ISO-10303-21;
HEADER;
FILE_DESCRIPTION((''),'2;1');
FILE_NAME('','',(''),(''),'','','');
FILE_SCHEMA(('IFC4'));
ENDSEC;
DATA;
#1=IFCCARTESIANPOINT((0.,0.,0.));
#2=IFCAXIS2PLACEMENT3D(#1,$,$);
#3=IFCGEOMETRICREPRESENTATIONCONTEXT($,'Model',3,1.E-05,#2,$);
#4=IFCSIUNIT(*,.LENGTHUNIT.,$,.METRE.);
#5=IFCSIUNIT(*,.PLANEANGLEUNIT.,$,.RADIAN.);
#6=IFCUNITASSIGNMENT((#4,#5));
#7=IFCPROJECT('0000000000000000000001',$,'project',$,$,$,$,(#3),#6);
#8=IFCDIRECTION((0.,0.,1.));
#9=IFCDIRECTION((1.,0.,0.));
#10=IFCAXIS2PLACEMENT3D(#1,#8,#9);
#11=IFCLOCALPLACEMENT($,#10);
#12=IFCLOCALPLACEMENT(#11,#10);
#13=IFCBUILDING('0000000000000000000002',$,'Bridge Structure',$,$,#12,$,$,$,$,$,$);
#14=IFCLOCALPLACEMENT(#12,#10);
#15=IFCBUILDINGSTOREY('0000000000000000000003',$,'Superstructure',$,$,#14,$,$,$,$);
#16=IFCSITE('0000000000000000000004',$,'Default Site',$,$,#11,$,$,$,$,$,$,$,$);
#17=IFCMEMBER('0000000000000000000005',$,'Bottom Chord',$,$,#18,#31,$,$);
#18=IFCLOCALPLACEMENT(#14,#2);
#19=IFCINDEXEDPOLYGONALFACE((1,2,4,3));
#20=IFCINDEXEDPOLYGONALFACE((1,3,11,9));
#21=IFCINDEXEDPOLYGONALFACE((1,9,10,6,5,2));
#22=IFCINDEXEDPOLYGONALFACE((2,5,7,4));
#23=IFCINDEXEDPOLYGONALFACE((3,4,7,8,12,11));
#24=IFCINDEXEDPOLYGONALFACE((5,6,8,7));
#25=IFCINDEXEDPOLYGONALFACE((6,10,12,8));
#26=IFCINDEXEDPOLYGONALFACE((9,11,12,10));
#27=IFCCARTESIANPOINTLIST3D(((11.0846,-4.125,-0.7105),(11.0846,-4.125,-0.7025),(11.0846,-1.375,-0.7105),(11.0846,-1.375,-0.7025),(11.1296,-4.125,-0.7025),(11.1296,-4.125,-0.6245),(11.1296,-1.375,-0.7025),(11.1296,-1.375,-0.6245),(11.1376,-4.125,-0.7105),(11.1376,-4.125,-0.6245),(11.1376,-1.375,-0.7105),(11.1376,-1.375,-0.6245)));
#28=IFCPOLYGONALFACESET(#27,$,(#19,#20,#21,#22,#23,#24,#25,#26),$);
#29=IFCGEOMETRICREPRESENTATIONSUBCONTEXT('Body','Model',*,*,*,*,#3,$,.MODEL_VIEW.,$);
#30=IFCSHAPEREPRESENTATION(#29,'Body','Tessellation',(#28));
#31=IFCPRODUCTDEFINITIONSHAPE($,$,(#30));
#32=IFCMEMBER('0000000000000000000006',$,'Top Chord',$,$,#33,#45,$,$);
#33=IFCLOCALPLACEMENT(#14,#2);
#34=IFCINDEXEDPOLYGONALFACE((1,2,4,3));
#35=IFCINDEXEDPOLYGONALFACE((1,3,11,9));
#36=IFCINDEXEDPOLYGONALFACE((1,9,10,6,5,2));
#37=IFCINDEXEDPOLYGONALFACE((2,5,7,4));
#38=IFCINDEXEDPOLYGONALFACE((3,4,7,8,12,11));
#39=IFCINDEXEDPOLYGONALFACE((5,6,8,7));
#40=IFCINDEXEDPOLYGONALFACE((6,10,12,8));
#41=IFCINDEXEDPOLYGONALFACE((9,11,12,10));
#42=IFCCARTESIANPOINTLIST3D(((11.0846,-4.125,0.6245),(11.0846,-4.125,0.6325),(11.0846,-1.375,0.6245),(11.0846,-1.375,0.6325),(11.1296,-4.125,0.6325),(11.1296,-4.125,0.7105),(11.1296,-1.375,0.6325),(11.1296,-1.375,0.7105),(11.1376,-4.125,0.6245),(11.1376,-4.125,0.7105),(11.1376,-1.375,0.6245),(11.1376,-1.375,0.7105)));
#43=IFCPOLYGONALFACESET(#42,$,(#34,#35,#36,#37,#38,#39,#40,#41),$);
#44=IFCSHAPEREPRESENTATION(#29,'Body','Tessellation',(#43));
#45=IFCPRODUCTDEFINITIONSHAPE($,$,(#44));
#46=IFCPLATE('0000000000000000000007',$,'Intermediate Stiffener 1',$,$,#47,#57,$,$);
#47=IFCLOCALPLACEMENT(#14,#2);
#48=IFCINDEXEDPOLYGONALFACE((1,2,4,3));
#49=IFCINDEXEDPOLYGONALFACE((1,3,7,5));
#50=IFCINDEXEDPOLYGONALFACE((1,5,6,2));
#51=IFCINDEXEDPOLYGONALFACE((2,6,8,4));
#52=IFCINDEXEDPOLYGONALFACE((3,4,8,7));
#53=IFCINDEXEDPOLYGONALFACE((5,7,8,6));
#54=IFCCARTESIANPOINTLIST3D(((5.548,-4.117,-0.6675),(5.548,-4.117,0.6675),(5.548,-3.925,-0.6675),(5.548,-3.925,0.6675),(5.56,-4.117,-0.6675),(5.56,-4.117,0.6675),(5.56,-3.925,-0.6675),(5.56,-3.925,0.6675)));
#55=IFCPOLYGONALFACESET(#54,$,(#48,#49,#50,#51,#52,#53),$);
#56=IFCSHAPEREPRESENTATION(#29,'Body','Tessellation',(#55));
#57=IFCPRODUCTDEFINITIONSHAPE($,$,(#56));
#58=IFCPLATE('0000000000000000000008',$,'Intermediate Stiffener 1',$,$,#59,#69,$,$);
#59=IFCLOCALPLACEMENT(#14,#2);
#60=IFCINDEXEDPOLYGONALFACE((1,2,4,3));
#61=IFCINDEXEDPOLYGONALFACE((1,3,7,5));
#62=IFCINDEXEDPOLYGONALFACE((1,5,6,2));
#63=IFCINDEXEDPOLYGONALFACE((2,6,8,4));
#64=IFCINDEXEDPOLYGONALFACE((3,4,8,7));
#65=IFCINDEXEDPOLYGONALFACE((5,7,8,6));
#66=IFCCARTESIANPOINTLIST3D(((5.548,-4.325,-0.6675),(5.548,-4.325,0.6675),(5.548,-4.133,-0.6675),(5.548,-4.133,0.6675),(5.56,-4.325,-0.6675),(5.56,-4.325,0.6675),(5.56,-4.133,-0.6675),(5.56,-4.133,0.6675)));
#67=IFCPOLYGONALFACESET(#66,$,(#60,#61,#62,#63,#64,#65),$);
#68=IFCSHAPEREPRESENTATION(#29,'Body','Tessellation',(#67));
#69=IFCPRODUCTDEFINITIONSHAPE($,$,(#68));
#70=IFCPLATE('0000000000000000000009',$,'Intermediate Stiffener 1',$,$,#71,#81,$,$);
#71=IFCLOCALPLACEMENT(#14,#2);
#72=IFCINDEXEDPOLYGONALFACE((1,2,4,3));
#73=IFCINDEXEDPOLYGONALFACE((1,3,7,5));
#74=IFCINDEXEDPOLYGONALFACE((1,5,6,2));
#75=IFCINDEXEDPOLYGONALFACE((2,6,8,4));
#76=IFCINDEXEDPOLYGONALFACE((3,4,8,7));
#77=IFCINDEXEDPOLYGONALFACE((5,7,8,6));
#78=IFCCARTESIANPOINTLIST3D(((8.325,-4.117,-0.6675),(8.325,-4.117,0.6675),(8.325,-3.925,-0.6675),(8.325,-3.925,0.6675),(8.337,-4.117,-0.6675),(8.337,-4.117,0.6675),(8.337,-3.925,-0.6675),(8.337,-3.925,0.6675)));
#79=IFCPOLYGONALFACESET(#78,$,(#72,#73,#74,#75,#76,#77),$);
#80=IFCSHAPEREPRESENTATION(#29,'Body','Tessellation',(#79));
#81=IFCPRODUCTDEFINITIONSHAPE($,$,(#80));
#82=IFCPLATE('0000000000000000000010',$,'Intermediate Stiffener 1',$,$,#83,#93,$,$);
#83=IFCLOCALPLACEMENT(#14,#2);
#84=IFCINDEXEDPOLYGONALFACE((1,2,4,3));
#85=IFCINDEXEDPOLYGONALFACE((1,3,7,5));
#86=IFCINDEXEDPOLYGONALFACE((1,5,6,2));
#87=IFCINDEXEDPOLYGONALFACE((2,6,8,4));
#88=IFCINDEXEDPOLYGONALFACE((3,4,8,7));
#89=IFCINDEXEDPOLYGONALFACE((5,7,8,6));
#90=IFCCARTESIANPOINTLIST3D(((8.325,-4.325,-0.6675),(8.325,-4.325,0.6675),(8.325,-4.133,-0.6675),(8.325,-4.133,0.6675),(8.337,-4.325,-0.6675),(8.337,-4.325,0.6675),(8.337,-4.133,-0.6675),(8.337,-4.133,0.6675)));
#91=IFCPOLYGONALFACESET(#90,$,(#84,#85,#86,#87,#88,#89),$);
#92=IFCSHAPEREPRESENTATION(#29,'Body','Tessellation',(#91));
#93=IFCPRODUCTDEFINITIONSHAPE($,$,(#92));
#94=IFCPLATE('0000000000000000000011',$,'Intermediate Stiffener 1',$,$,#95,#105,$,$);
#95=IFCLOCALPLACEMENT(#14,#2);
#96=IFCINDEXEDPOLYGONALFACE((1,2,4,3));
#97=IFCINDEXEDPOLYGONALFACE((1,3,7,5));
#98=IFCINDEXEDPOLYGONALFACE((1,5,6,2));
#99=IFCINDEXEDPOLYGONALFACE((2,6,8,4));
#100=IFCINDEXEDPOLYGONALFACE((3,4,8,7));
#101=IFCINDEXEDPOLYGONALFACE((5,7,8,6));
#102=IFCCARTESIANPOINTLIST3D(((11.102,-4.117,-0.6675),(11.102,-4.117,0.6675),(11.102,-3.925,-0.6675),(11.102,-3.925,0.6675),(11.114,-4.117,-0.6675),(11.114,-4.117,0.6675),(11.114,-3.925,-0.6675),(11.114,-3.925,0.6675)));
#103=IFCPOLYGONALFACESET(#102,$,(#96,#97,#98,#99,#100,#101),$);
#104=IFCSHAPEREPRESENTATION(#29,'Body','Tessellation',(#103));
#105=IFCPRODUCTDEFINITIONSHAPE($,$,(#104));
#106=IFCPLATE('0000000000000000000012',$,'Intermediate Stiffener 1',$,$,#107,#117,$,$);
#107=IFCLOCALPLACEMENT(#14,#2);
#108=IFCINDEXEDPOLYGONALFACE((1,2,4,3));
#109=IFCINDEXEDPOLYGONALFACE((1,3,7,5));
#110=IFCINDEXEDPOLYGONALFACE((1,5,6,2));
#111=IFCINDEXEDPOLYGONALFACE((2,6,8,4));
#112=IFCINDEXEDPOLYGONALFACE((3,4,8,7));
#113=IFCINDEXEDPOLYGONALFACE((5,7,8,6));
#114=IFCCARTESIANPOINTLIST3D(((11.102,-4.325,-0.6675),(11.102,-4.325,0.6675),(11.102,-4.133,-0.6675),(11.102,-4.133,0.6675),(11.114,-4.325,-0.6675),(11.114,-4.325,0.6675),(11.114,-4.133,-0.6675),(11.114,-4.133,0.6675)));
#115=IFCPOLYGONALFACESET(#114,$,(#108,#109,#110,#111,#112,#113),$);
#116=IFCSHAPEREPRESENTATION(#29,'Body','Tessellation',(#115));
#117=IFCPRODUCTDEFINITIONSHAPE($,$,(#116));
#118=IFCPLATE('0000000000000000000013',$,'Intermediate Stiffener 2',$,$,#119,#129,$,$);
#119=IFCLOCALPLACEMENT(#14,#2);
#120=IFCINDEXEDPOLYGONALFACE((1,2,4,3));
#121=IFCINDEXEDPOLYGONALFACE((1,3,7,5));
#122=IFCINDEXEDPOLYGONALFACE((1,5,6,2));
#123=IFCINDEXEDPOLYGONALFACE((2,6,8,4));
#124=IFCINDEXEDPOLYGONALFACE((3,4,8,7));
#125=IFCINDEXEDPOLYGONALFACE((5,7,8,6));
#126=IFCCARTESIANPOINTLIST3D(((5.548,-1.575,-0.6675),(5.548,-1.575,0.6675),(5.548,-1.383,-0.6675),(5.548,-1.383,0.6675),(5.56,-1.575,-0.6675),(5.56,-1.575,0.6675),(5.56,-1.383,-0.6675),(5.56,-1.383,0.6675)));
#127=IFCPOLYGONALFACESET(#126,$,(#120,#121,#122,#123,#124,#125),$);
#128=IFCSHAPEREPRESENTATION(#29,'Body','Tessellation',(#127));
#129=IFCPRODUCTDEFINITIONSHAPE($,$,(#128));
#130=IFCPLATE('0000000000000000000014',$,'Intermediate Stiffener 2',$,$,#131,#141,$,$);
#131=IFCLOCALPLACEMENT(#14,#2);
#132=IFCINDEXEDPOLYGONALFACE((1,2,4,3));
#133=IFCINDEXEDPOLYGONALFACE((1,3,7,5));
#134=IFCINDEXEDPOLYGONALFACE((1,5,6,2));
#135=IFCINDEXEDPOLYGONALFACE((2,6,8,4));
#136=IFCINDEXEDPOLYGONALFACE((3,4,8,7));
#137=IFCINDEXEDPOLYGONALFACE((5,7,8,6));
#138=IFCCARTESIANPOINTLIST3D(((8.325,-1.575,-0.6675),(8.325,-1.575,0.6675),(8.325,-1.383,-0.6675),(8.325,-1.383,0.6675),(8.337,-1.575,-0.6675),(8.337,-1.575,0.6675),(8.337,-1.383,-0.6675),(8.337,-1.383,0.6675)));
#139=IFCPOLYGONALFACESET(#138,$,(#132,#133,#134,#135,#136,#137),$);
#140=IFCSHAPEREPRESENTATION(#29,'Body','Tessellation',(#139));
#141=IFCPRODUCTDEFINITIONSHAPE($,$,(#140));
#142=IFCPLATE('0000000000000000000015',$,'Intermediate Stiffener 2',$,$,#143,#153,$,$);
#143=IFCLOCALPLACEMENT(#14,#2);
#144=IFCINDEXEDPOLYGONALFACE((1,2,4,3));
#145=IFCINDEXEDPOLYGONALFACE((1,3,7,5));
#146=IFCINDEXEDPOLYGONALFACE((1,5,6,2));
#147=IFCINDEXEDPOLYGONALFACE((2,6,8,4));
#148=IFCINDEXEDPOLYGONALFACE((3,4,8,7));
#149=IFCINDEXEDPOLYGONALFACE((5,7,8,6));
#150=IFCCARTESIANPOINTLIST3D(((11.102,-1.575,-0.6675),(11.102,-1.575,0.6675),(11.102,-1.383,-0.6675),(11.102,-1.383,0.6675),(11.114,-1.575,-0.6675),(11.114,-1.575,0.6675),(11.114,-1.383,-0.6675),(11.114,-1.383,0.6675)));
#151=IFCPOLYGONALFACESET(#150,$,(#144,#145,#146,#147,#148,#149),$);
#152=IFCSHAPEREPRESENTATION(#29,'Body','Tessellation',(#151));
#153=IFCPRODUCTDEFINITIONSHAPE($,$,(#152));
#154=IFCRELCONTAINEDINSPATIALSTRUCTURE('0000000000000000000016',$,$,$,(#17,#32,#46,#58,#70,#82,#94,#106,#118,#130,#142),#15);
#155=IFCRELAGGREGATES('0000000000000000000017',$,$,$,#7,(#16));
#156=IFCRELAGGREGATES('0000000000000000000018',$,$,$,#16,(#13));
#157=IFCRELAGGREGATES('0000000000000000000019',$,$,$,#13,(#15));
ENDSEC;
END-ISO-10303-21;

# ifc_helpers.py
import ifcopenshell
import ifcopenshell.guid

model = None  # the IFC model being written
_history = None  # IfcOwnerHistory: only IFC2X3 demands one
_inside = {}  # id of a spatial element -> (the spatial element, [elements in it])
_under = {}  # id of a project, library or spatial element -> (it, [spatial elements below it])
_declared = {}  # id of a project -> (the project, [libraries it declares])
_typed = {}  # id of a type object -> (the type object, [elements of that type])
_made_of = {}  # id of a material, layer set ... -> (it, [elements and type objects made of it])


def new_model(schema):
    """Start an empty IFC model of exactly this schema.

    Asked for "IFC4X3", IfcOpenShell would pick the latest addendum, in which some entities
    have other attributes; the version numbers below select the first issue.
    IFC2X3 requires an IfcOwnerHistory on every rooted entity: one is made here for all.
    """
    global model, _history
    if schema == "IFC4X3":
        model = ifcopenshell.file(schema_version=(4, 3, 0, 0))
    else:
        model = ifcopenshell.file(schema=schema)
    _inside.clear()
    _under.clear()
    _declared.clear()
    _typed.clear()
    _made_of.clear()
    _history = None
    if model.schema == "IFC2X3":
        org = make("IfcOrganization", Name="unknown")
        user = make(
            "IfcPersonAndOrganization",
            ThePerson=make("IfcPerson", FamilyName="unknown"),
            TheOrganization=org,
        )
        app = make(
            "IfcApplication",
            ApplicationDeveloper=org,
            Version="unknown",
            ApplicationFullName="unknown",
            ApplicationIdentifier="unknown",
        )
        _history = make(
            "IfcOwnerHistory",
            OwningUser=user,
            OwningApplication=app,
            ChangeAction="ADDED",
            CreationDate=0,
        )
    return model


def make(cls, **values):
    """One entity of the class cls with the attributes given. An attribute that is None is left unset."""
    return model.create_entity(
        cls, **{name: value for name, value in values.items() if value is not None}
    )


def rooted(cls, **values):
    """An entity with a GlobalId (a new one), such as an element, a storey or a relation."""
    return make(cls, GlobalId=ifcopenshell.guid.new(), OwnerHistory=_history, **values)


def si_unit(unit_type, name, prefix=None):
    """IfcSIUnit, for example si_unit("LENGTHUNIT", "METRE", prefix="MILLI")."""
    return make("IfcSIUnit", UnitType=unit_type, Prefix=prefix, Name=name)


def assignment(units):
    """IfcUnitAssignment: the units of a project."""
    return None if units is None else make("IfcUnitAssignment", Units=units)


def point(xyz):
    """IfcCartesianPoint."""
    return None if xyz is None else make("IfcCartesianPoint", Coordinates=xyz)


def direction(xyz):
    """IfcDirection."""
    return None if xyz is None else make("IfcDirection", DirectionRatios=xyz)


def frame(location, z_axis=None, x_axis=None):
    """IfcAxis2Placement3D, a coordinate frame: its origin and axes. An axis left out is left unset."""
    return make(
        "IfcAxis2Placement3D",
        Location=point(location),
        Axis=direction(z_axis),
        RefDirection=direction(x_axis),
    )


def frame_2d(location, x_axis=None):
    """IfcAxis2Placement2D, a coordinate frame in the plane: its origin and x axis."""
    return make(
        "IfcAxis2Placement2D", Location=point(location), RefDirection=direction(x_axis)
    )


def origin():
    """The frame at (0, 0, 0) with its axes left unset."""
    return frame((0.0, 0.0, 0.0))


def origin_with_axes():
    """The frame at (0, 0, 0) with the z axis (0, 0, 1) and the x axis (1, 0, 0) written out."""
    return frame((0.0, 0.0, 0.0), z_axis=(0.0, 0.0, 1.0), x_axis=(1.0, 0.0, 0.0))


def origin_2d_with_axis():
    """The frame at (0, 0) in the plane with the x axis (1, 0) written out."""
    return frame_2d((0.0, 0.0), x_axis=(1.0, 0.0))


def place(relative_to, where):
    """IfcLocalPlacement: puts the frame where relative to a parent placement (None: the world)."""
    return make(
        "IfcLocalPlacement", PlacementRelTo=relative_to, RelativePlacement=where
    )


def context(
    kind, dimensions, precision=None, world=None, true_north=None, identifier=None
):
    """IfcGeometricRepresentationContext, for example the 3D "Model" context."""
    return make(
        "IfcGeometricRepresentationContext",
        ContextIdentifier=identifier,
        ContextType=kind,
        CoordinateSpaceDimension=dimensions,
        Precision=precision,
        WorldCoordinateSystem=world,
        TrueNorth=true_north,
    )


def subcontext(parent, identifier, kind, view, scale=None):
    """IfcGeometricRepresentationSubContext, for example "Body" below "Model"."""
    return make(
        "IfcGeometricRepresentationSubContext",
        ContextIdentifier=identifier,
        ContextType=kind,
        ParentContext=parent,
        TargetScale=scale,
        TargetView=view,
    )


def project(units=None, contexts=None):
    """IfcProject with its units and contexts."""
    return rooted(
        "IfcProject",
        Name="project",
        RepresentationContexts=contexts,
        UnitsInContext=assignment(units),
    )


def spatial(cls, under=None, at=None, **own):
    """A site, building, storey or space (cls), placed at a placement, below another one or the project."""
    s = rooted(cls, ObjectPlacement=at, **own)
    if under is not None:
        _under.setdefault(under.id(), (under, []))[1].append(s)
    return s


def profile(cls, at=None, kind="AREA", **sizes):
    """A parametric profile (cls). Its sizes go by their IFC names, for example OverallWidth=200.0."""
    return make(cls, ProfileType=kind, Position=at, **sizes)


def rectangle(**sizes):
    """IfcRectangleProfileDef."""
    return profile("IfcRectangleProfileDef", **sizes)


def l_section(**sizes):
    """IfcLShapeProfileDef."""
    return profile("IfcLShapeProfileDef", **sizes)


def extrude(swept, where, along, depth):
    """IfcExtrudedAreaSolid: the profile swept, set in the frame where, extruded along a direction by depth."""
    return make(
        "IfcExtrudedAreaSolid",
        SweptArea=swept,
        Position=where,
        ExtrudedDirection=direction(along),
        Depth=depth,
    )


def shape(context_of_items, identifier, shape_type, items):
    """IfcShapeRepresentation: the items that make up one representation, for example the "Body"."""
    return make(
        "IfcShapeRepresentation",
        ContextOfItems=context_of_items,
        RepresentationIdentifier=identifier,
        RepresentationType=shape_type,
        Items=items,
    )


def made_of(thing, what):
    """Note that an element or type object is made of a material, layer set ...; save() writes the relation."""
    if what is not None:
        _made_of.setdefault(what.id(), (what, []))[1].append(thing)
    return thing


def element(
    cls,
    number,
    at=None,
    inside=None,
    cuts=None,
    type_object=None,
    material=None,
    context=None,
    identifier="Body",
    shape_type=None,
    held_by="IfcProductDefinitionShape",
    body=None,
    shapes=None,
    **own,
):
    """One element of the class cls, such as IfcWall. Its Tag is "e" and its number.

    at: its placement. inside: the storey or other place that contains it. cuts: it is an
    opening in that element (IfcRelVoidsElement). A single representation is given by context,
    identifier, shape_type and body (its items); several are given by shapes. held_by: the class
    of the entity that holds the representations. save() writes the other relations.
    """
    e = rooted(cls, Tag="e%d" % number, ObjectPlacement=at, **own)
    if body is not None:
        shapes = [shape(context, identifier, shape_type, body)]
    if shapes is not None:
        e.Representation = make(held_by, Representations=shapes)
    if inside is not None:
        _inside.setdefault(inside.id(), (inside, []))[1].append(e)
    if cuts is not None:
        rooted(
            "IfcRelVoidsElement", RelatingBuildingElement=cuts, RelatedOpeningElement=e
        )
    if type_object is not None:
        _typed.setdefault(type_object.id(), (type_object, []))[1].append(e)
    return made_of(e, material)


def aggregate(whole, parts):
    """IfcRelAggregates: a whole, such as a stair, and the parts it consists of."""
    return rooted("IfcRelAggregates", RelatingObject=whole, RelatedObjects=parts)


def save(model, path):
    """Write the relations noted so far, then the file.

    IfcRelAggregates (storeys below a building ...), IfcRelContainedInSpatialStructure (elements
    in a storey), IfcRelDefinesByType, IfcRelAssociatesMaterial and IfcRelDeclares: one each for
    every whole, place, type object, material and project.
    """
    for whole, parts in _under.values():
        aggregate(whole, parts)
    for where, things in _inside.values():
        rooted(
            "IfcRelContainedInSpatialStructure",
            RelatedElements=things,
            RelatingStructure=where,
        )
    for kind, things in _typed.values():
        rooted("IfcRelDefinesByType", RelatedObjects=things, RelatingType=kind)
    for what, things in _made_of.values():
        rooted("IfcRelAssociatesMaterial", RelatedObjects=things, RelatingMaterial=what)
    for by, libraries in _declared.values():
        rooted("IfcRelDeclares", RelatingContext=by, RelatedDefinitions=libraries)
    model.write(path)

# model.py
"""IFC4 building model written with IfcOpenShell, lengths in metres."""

from ifc_helpers import new_model, si_unit, frame, origin, origin_with_axes, origin_2d_with_axis, place, context, subcontext, project, spatial, rectangle, l_section, extrude, element, save


model = new_model("IFC4")

# Units and contexts
model_context = context("Model", 3, precision=1e-05, world=origin())
body_context = subcontext(model_context, "Body", "Model", "MODEL_VIEW")
ifc_project = project(units=[si_unit("LENGTHUNIT", "METRE"), si_unit("PLANEANGLEUNIT", "RADIAN")], contexts=[model_context])

# Site, building, storey
site_placement = place(None, origin_with_axes())
site = spatial("IfcSite", under=ifc_project, at=site_placement, Name="Default Site")
building_placement = place(site_placement, origin_with_axes())
building = spatial("IfcBuilding", under=site, at=building_placement, Name="Bridge Structure")
storey_placement = place(building_placement, origin_with_axes())
storey = spatial("IfcBuildingStorey", under=building, at=storey_placement, Name="Superstructure")

# Members
for number, where, z_axis, x_axis, name in (
    (1, (11.1111, -4.125, -0.6675), (0.0, 1.0, 0.0), (-1.0, 0.0, 0.0), "Bottom Chord"),
    (2, (11.1111, -4.125, 0.6675), (0.0, 1.0, 0.0), (-1.0, 0.0, 0.0), "Top Chord"),
):
    element("IfcMember", number, at=place(storey_placement, frame(where, z_axis=z_axis, x_axis=x_axis)), inside=storey, Name=name, context=body_context, shape_type="SweptSolid", body=[
        extrude(l_section(Depth=0.086, Width=0.053, Thickness=0.008, at=origin_2d_with_axis()), origin_with_axes(), (0.0, 0.0, 1.0), 2.75),
    ])

# Plates
for number, where, z_axis, x_axis, name in (
    (3, (5.554, -4.021, -0.6675), (0.0, 0.0, 1.0), (1.0, 0.0, 0.0), "Intermediate Stiffener 1"),
    (4, (5.554, -4.229, -0.6675), (0.0, 0.0, 1.0), (1.0, 0.0, 0.0), "Intermediate Stiffener 1"),
    (5, (8.331, -4.021, -0.6675), (0.0, 0.0, 1.0), (1.0, 0.0, 0.0), "Intermediate Stiffener 1"),
    (6, (8.331, -4.229, -0.6675), (0.0, 0.0, 1.0), (1.0, 0.0, 0.0), "Intermediate Stiffener 1"),
    (7, (11.108, -4.021, -0.6675), (0.0, 0.0, 1.0), (1.0, 0.0, 0.0), "Intermediate Stiffener 1"),
    (8, (11.108, -4.229, -0.6675), (0.0, 0.0, 1.0), (1.0, 0.0, 0.0), "Intermediate Stiffener 1"),
    (9, (5.554, -1.479, -0.6675), (0.0, 0.0, 1.0), (1.0, 0.0, 0.0), "Intermediate Stiffener 2"),
    (10, (8.331, -1.479, -0.6675), (0.0, 0.0, 1.0), (1.0, 0.0, 0.0), "Intermediate Stiffener 2"),
    (11, (11.108, -1.479, -0.6675), (0.0, 0.0, 1.0), (1.0, 0.0, 0.0), "Intermediate Stiffener 2"),
):
    element("IfcPlate", number, at=place(storey_placement, frame(where, z_axis=z_axis, x_axis=x_axis)), inside=storey, Name=name, context=body_context, shape_type="SweptSolid", body=[
        extrude(rectangle(XDim=0.012, YDim=0.192, at=origin_2d_with_axis()), origin_with_axes(), (0.0, 0.0, 1.0), 1.335),
    ])

save(model, "model.ifc")
